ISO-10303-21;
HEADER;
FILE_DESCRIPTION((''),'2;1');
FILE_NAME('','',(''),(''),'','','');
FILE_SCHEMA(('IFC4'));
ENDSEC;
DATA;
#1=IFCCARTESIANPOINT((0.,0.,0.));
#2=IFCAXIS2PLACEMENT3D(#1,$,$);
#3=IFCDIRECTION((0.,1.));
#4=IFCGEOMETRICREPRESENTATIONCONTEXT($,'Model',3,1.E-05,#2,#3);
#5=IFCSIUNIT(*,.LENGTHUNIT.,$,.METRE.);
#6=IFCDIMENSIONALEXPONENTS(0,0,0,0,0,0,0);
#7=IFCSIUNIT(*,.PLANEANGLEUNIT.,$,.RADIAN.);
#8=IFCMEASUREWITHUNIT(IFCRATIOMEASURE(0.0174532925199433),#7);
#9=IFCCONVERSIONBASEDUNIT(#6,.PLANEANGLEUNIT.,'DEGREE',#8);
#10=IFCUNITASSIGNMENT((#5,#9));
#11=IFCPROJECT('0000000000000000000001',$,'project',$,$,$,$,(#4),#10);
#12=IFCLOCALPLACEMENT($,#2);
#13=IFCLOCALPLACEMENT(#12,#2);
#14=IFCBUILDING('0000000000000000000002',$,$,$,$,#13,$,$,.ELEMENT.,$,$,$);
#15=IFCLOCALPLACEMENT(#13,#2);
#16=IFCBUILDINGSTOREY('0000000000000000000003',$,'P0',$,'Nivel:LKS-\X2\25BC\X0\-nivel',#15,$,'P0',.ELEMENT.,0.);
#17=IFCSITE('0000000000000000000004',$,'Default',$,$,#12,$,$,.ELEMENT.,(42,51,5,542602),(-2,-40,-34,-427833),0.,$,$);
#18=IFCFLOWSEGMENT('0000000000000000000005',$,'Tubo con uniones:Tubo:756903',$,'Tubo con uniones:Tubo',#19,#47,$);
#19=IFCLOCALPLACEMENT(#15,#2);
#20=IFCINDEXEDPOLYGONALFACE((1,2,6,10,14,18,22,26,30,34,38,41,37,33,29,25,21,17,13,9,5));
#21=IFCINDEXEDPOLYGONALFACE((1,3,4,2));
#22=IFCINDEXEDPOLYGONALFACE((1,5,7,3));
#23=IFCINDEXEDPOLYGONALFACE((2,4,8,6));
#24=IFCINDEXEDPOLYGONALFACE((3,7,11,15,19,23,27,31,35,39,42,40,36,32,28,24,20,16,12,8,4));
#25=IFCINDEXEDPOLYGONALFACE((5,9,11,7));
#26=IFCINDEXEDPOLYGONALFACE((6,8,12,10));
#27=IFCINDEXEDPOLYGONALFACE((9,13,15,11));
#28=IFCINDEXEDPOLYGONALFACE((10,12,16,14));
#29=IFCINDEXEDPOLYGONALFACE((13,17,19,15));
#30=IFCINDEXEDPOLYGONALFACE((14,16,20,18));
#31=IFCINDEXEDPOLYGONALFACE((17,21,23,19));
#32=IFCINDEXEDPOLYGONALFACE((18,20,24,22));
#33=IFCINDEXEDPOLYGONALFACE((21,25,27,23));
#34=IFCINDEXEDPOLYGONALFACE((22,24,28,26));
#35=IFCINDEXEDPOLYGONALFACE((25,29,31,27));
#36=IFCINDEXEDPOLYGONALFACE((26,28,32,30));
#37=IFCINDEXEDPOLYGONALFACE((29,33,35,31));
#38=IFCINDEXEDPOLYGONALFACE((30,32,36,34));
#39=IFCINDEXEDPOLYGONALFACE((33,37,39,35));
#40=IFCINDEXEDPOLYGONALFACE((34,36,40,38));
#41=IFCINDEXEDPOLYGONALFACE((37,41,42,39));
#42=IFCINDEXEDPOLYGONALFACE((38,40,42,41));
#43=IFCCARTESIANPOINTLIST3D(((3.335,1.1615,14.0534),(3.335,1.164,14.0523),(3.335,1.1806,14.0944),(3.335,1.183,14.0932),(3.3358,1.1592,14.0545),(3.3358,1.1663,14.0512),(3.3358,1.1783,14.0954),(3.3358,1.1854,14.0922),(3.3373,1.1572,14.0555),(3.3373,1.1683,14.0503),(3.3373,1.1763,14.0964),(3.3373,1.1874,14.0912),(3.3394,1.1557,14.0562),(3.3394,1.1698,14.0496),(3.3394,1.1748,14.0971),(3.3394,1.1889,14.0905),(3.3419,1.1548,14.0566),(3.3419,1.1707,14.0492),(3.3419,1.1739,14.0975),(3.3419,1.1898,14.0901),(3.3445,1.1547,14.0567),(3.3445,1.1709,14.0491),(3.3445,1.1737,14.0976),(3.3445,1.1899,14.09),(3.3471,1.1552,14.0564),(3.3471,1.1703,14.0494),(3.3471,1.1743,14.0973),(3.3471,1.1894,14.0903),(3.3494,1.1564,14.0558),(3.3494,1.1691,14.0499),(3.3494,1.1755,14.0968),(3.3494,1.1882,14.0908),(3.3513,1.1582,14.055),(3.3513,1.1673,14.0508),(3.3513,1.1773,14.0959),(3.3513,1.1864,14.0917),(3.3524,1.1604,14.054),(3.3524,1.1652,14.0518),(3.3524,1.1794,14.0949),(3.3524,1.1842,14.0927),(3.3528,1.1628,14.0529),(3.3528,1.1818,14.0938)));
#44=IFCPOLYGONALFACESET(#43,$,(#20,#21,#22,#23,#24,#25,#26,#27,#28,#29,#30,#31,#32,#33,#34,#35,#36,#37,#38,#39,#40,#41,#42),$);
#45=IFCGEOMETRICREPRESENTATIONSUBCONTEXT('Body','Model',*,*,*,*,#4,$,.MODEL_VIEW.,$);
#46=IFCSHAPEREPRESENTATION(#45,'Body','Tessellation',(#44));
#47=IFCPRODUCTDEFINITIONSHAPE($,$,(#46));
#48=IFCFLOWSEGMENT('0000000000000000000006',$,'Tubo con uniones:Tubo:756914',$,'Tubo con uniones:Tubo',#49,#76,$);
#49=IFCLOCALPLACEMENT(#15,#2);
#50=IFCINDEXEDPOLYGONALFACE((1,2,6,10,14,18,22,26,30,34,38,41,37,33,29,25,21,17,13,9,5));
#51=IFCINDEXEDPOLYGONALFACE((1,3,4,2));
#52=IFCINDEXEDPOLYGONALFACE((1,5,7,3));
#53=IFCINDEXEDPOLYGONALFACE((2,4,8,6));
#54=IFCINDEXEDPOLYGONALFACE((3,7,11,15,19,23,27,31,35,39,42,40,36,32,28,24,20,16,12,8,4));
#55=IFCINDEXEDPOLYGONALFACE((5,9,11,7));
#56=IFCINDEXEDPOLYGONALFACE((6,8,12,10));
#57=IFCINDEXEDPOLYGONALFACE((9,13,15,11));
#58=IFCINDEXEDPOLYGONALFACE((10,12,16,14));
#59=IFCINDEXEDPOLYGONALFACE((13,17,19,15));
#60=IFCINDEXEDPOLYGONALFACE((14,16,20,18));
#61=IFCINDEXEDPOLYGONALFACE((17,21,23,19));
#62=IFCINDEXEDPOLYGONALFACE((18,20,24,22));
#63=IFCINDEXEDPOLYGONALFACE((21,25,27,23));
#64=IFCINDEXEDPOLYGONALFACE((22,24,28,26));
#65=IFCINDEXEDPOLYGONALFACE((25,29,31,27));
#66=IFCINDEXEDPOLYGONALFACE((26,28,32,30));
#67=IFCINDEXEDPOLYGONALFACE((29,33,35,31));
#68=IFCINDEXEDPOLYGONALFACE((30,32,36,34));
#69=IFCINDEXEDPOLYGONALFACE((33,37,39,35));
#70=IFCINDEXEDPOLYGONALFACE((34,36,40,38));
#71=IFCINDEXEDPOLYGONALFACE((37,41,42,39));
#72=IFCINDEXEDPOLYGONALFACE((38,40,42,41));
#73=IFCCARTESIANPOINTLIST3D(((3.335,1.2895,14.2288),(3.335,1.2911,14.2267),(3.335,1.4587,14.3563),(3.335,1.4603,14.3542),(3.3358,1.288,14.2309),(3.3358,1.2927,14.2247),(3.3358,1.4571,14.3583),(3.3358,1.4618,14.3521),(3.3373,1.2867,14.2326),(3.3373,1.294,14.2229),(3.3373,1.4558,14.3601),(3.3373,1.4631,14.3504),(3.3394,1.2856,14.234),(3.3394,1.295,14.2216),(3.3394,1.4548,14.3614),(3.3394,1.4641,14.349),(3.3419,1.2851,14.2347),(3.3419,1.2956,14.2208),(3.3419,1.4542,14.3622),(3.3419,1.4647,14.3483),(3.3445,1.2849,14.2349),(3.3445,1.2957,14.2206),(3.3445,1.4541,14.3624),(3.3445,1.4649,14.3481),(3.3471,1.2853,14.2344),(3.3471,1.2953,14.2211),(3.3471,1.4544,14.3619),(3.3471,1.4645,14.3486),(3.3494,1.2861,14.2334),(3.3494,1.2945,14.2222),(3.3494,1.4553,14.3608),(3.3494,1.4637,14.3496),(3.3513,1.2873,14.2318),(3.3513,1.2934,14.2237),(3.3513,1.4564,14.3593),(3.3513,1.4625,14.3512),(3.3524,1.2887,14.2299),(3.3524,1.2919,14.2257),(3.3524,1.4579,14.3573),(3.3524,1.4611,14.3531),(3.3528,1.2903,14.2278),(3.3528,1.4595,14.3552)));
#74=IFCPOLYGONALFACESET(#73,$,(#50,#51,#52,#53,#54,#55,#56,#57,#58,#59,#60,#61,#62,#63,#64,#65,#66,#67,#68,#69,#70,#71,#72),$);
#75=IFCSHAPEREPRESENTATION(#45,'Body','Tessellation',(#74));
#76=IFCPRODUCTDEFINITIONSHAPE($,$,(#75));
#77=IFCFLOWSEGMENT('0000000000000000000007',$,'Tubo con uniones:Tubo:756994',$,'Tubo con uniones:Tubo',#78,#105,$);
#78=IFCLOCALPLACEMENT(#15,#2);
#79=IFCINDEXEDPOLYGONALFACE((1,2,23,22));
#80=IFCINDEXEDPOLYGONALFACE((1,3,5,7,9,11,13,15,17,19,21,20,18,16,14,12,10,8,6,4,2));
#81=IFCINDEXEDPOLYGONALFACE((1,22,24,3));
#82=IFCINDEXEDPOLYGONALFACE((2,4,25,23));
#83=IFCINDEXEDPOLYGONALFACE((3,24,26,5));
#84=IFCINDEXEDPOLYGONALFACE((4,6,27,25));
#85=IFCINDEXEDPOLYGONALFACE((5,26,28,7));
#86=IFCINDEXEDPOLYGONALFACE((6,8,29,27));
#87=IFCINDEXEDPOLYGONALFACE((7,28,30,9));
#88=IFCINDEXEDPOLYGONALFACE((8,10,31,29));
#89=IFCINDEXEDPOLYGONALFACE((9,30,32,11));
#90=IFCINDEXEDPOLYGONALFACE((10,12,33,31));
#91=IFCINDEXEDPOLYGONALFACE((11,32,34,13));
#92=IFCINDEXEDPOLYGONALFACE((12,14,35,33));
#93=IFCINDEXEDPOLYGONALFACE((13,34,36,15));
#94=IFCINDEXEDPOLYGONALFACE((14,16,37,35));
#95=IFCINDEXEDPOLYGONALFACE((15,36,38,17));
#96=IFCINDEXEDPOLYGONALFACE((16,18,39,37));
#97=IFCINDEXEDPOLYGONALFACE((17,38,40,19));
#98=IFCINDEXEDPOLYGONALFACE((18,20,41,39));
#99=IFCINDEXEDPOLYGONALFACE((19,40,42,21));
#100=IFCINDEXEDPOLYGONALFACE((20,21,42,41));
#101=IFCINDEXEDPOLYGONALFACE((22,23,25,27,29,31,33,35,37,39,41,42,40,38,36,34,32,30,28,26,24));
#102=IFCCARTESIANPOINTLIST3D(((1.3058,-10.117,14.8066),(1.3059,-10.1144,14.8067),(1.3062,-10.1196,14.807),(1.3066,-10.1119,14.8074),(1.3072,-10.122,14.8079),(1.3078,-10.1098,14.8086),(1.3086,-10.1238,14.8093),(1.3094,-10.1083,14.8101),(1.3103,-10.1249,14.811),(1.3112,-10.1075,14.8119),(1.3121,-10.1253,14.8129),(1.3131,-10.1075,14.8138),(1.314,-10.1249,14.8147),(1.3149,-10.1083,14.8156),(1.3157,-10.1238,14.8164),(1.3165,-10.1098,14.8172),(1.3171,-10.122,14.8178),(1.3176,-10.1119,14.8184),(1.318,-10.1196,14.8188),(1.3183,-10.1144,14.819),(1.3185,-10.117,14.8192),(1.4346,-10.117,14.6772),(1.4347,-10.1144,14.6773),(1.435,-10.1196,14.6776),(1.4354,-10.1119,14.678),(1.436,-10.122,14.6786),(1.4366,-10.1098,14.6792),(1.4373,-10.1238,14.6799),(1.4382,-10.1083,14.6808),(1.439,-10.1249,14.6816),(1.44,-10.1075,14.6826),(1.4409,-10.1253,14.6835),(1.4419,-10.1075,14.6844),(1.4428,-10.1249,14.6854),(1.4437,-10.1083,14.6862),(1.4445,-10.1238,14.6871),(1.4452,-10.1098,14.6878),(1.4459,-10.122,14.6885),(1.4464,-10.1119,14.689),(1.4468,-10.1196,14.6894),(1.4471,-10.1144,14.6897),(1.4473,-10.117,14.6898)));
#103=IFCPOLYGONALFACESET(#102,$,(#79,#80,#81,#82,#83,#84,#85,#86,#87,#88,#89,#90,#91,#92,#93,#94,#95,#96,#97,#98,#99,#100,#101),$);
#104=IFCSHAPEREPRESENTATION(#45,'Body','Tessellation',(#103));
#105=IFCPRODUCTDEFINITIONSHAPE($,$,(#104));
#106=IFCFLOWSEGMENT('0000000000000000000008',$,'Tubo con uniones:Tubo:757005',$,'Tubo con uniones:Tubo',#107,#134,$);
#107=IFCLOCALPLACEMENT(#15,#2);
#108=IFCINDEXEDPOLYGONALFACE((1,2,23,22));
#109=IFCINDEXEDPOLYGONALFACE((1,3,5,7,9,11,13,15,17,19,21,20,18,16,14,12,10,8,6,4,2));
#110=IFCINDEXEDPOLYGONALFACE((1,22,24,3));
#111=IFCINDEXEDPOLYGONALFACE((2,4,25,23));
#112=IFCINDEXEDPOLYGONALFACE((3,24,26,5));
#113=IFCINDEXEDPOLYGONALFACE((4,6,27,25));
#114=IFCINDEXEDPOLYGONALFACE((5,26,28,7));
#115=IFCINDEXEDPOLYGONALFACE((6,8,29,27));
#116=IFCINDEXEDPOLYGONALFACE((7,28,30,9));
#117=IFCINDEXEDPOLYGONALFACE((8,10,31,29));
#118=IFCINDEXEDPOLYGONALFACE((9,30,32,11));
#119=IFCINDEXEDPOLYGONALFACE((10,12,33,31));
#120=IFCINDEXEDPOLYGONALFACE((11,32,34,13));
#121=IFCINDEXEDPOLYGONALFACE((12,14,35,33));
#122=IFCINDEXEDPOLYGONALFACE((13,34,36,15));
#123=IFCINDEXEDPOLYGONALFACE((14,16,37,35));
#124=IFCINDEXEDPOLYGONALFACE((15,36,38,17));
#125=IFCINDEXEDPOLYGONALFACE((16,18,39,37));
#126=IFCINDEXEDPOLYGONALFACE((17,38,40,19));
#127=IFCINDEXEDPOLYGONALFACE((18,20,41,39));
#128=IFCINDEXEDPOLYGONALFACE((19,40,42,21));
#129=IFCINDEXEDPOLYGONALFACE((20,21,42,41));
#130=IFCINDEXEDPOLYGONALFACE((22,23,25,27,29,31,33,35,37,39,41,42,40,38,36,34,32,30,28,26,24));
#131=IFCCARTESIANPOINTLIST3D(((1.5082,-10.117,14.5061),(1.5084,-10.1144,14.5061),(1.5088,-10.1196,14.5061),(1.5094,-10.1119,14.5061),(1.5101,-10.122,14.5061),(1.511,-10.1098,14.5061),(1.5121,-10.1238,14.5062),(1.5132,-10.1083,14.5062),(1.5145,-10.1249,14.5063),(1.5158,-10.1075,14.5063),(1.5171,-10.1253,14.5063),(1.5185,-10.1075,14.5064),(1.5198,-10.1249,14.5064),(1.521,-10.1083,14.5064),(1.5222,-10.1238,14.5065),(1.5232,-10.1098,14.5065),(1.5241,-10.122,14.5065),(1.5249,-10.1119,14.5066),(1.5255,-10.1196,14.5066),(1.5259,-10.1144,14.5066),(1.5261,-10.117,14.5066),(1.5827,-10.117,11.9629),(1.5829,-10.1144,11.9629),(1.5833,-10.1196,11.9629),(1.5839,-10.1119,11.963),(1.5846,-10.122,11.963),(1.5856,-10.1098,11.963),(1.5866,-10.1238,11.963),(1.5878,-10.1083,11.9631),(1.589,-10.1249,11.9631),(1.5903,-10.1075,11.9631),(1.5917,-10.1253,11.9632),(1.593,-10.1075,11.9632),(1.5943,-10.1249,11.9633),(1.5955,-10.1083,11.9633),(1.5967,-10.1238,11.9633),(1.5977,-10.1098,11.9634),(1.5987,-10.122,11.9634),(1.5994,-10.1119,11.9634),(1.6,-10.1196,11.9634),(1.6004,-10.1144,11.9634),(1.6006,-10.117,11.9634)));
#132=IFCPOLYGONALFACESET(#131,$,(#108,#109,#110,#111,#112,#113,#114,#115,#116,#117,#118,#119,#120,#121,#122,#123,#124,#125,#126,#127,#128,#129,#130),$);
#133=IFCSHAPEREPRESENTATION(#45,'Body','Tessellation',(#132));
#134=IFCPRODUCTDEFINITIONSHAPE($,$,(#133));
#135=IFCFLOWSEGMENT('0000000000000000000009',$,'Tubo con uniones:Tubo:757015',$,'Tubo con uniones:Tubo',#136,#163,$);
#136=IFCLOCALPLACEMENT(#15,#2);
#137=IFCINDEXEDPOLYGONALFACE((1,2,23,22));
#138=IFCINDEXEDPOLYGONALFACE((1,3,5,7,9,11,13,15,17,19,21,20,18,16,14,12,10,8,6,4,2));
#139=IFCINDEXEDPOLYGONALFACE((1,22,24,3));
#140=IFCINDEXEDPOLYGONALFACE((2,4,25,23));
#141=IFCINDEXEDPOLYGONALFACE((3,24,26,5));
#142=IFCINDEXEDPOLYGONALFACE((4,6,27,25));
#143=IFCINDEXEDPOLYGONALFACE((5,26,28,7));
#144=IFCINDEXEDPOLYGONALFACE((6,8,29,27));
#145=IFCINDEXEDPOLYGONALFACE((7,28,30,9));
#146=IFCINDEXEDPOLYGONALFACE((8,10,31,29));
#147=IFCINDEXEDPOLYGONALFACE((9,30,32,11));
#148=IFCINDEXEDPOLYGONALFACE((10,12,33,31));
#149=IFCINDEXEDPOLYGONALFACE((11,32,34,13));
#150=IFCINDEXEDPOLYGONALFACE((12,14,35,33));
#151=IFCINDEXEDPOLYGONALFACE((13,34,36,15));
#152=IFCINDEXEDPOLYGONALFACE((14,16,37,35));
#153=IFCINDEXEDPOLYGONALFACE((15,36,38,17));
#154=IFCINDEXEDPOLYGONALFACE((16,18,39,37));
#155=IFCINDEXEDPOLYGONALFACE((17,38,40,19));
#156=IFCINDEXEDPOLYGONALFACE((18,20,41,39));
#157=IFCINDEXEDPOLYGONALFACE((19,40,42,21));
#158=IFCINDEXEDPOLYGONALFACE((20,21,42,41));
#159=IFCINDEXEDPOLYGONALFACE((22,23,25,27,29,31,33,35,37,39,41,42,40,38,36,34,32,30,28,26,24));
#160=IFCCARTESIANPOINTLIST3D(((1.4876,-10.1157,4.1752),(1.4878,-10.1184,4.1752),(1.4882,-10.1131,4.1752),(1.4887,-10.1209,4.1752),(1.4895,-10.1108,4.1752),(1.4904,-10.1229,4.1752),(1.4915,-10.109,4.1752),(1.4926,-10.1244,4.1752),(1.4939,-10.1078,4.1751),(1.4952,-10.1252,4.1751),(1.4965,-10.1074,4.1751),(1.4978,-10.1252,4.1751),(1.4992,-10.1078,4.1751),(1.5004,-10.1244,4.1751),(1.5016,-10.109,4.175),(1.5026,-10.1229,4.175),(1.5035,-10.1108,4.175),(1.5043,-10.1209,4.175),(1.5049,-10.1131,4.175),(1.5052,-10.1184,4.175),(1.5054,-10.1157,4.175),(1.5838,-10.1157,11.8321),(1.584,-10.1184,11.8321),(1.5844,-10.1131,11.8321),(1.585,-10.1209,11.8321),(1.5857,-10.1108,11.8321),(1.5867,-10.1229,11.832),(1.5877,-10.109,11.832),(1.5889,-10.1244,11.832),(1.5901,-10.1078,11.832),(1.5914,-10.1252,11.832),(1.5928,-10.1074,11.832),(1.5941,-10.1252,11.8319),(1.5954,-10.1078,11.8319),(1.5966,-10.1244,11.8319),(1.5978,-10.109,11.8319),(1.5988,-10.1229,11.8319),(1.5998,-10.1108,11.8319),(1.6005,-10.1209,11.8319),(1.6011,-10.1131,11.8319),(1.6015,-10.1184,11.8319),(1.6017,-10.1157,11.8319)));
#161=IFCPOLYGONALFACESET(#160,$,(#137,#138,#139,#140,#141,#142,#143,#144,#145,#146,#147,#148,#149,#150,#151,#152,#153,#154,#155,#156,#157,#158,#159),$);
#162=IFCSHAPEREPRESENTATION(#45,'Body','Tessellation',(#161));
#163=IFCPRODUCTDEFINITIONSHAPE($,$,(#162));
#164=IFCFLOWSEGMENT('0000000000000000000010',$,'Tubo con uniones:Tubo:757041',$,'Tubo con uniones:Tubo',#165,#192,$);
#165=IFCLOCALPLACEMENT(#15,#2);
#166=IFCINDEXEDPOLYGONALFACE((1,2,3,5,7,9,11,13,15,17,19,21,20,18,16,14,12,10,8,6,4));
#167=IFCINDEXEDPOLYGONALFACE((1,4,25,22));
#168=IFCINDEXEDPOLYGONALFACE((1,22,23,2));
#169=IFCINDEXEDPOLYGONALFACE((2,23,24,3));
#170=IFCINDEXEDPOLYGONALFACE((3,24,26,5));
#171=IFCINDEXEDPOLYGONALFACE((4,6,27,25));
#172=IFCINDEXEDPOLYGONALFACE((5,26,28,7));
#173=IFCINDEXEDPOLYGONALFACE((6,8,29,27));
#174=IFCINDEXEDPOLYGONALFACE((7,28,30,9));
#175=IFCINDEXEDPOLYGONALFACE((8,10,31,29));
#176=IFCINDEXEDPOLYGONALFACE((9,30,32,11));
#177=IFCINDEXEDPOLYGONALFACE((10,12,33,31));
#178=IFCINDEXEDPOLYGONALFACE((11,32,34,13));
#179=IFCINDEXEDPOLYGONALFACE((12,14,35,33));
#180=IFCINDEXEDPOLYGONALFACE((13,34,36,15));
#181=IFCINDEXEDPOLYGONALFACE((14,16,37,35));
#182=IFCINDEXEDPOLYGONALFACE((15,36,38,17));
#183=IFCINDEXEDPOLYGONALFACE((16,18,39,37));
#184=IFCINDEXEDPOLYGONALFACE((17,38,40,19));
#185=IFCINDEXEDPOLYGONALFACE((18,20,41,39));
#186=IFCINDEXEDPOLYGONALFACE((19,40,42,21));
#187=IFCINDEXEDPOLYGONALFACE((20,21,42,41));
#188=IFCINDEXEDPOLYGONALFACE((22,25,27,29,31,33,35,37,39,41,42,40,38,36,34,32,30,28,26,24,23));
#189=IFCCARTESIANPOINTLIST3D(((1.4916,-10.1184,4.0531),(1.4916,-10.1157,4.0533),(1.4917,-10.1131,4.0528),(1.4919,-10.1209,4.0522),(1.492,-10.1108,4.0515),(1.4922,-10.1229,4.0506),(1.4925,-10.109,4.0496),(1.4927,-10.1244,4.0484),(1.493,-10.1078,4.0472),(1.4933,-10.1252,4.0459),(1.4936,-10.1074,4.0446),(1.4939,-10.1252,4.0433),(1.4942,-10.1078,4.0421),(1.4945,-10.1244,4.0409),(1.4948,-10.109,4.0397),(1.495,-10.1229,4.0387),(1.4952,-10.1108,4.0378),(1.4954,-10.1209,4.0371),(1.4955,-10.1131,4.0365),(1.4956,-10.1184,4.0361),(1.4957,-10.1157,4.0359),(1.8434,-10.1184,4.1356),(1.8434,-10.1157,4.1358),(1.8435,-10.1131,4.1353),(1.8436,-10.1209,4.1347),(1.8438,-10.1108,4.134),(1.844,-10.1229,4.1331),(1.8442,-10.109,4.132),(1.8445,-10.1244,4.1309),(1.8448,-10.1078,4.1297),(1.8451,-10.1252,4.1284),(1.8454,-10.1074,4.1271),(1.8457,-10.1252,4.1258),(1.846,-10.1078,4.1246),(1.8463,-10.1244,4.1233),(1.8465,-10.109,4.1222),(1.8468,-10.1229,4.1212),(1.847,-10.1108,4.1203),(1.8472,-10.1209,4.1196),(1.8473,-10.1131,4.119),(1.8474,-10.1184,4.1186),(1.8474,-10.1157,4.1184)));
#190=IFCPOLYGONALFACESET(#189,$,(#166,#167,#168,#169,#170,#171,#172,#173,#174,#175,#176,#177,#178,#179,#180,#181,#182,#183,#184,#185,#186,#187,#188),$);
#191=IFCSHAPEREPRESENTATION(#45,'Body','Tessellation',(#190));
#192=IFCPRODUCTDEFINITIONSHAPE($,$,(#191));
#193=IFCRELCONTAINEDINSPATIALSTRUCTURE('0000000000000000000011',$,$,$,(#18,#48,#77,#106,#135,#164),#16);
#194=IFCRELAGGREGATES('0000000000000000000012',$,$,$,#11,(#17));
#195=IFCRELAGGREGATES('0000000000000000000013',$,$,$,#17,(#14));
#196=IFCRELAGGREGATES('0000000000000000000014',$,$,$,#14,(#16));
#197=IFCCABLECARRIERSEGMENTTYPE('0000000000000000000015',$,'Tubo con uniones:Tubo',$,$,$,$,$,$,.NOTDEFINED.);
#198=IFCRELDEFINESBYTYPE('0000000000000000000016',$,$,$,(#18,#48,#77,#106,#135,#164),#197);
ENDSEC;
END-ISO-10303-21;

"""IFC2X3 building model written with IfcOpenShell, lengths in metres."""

from ifc_helpers import new_model, entity, si_unit, converted_unit, direction, frame, frame_2d, origin, origin_2d_with_axis, place, context, subcontext, project, spatial, circle, extrude, type_object, element, save


model = new_model("IFC2X3")

# Units and contexts
model_context = context("Model", 3, precision=1e-05, world=origin(), true_north=direction((0.0, 1.0)))
body_context = subcontext(model_context, "Body", "Model", "MODEL_VIEW")
ifc_project = project(units=[si_unit("LENGTHUNIT", "METRE"), converted_unit("PLANEANGLEUNIT", "DEGREE", entity("IfcRatioMeasure", 0.0174532925199433), si_unit("PLANEANGLEUNIT", "RADIAN"), dimensions=[0, 0, 0, 0, 0, 0, 0])], contexts=[model_context])

# Site, building, storey
site_placement = place(None, origin())
site = spatial("IfcSite", under=ifc_project, at=site_placement, Name="Default", CompositionType="ELEMENT", RefLatitude=(42, 51, 5, 542602), RefLongitude=(-2, -40, -34, -427833), RefElevation=0.0)
building_placement = place(site_placement, origin())
building = spatial("IfcBuilding", under=site, at=building_placement, CompositionType="ELEMENT")
storey_placement = place(building_placement, origin())
storey = spatial("IfcBuildingStorey", under=building, at=storey_placement, Name="P0", ObjectType="Nivel:LKS-▼-nivel", LongName="P0", CompositionType="ELEMENT", Elevation=0.0)

# Flow segments
cable_carrier_segment_type = type_object("IfcCableCarrierSegmentType", Name="Tubo con uniones:Tubo", PredefinedType="NOTDEFINED")
flow_segment_1_placement = place(storey_placement, origin())
element("IfcFlowSegment", 1, at=flow_segment_1_placement, inside=storey, type_object=cable_carrier_segment_type, Name="Tubo con uniones:Tubo:756903", ObjectType="Tubo con uniones:Tubo", context=body_context, shape_type="SweptSolid", body=[
    extrude(circle(Radius=0.009, at=frame_2d((0.0, 0.0), x_axis=(1.0, 0.0))), frame((3.3439, 1.1628, 14.0529), z_axis=(0.0, 0.422618, 0.906308), x_axis=(1.0, 0.0, 0.0)), (0.0, 0.0, 1.0), 0.0451),
])
flow_segment_2_placement = place(storey_placement, origin())
element("IfcFlowSegment", 2, at=flow_segment_2_placement, inside=storey, type_object=cable_carrier_segment_type, Name="Tubo con uniones:Tubo:756914", ObjectType="Tubo con uniones:Tubo", context=body_context, shape_type="SweptSolid", body=[
    extrude(circle(Radius=0.009, at=frame_2d((0.0, 0.0), x_axis=(1.0, 0.0))), frame((3.3439, 1.2903, 14.2278), z_axis=(0.0, 0.798636, 0.601815), x_axis=(1.0, 0.0, 0.0)), (0.0, 0.0, 1.0), 0.2118),
])
flow_segment_3_placement = place(storey_placement, origin())
element("IfcFlowSegment", 3, at=flow_segment_3_placement, inside=storey, type_object=cable_carrier_segment_type, Name="Tubo con uniones:Tubo:756994", ObjectType="Tubo con uniones:Tubo", context=body_context, shape_type="SweptSolid", body=[
    extrude(circle(Radius=0.009, at=frame_2d((0.0, 0.0), x_axis=(1.0, 0.0))), frame((1.4409, -10.1164, 14.6835), z_axis=(-0.705482, 0.0, 0.708728), x_axis=(0.0, -1.0, 0.0)), (0.0, 0.0, 1.0), 0.1825),
])
flow_segment_4_placement = place(storey_placement, origin())
element("IfcFlowSegment", 4, at=flow_segment_4_placement, inside=storey, type_object=cable_carrier_segment_type, Name="Tubo con uniones:Tubo:757005", ObjectType="Tubo con uniones:Tubo", context=body_context, shape_type="SweptSolid", body=[
    extrude(circle(Radius=0.009, at=origin_2d_with_axis()), frame((1.5917, -10.1164, 11.9632), z_axis=(-0.029293, 0.0, 0.999571), x_axis=(0.0, -1.0, 0.0)), (0.0, 0.0, 1.0), 2.5442),
])
flow_segment_5_placement = place(storey_placement, origin())
element("IfcFlowSegment", 5, at=flow_segment_5_placement, inside=storey, type_object=cable_carrier_segment_type, Name="Tubo con uniones:Tubo:757015", ObjectType="Tubo con uniones:Tubo", context=body_context, shape_type="SweptSolid", body=[
    extrude(circle(Radius=0.009, at=frame_2d((0.0, 0.0), x_axis=(1.0, 0.0))), frame((1.4965, -10.1164, 4.1751), z_axis=(0.012568, 0.0, 0.999921), x_axis=(0.0, 1.0, 0.0)), (0.0, 0.0, 1.0), 7.6575),
])
flow_segment_6_placement = place(storey_placement, origin())
element("IfcFlowSegment", 6, at=flow_segment_6_placement, inside=storey, type_object=cable_carrier_segment_type, Name="Tubo con uniones:Tubo:757041", ObjectType="Tubo con uniones:Tubo", context=body_context, shape_type="SweptSolid", body=[
    extrude(circle(Radius=0.009, at=frame_2d((0.0, 0.0), x_axis=(1.0, 0.0))), frame((1.4936, -10.1164, 4.0446), z_axis=(0.97359, 0.0, 0.228303), x_axis=(0.0, 1.0, 0.0)), (0.0, 0.0, 1.0), 0.3613),
])

save(model, "model.ifc")
